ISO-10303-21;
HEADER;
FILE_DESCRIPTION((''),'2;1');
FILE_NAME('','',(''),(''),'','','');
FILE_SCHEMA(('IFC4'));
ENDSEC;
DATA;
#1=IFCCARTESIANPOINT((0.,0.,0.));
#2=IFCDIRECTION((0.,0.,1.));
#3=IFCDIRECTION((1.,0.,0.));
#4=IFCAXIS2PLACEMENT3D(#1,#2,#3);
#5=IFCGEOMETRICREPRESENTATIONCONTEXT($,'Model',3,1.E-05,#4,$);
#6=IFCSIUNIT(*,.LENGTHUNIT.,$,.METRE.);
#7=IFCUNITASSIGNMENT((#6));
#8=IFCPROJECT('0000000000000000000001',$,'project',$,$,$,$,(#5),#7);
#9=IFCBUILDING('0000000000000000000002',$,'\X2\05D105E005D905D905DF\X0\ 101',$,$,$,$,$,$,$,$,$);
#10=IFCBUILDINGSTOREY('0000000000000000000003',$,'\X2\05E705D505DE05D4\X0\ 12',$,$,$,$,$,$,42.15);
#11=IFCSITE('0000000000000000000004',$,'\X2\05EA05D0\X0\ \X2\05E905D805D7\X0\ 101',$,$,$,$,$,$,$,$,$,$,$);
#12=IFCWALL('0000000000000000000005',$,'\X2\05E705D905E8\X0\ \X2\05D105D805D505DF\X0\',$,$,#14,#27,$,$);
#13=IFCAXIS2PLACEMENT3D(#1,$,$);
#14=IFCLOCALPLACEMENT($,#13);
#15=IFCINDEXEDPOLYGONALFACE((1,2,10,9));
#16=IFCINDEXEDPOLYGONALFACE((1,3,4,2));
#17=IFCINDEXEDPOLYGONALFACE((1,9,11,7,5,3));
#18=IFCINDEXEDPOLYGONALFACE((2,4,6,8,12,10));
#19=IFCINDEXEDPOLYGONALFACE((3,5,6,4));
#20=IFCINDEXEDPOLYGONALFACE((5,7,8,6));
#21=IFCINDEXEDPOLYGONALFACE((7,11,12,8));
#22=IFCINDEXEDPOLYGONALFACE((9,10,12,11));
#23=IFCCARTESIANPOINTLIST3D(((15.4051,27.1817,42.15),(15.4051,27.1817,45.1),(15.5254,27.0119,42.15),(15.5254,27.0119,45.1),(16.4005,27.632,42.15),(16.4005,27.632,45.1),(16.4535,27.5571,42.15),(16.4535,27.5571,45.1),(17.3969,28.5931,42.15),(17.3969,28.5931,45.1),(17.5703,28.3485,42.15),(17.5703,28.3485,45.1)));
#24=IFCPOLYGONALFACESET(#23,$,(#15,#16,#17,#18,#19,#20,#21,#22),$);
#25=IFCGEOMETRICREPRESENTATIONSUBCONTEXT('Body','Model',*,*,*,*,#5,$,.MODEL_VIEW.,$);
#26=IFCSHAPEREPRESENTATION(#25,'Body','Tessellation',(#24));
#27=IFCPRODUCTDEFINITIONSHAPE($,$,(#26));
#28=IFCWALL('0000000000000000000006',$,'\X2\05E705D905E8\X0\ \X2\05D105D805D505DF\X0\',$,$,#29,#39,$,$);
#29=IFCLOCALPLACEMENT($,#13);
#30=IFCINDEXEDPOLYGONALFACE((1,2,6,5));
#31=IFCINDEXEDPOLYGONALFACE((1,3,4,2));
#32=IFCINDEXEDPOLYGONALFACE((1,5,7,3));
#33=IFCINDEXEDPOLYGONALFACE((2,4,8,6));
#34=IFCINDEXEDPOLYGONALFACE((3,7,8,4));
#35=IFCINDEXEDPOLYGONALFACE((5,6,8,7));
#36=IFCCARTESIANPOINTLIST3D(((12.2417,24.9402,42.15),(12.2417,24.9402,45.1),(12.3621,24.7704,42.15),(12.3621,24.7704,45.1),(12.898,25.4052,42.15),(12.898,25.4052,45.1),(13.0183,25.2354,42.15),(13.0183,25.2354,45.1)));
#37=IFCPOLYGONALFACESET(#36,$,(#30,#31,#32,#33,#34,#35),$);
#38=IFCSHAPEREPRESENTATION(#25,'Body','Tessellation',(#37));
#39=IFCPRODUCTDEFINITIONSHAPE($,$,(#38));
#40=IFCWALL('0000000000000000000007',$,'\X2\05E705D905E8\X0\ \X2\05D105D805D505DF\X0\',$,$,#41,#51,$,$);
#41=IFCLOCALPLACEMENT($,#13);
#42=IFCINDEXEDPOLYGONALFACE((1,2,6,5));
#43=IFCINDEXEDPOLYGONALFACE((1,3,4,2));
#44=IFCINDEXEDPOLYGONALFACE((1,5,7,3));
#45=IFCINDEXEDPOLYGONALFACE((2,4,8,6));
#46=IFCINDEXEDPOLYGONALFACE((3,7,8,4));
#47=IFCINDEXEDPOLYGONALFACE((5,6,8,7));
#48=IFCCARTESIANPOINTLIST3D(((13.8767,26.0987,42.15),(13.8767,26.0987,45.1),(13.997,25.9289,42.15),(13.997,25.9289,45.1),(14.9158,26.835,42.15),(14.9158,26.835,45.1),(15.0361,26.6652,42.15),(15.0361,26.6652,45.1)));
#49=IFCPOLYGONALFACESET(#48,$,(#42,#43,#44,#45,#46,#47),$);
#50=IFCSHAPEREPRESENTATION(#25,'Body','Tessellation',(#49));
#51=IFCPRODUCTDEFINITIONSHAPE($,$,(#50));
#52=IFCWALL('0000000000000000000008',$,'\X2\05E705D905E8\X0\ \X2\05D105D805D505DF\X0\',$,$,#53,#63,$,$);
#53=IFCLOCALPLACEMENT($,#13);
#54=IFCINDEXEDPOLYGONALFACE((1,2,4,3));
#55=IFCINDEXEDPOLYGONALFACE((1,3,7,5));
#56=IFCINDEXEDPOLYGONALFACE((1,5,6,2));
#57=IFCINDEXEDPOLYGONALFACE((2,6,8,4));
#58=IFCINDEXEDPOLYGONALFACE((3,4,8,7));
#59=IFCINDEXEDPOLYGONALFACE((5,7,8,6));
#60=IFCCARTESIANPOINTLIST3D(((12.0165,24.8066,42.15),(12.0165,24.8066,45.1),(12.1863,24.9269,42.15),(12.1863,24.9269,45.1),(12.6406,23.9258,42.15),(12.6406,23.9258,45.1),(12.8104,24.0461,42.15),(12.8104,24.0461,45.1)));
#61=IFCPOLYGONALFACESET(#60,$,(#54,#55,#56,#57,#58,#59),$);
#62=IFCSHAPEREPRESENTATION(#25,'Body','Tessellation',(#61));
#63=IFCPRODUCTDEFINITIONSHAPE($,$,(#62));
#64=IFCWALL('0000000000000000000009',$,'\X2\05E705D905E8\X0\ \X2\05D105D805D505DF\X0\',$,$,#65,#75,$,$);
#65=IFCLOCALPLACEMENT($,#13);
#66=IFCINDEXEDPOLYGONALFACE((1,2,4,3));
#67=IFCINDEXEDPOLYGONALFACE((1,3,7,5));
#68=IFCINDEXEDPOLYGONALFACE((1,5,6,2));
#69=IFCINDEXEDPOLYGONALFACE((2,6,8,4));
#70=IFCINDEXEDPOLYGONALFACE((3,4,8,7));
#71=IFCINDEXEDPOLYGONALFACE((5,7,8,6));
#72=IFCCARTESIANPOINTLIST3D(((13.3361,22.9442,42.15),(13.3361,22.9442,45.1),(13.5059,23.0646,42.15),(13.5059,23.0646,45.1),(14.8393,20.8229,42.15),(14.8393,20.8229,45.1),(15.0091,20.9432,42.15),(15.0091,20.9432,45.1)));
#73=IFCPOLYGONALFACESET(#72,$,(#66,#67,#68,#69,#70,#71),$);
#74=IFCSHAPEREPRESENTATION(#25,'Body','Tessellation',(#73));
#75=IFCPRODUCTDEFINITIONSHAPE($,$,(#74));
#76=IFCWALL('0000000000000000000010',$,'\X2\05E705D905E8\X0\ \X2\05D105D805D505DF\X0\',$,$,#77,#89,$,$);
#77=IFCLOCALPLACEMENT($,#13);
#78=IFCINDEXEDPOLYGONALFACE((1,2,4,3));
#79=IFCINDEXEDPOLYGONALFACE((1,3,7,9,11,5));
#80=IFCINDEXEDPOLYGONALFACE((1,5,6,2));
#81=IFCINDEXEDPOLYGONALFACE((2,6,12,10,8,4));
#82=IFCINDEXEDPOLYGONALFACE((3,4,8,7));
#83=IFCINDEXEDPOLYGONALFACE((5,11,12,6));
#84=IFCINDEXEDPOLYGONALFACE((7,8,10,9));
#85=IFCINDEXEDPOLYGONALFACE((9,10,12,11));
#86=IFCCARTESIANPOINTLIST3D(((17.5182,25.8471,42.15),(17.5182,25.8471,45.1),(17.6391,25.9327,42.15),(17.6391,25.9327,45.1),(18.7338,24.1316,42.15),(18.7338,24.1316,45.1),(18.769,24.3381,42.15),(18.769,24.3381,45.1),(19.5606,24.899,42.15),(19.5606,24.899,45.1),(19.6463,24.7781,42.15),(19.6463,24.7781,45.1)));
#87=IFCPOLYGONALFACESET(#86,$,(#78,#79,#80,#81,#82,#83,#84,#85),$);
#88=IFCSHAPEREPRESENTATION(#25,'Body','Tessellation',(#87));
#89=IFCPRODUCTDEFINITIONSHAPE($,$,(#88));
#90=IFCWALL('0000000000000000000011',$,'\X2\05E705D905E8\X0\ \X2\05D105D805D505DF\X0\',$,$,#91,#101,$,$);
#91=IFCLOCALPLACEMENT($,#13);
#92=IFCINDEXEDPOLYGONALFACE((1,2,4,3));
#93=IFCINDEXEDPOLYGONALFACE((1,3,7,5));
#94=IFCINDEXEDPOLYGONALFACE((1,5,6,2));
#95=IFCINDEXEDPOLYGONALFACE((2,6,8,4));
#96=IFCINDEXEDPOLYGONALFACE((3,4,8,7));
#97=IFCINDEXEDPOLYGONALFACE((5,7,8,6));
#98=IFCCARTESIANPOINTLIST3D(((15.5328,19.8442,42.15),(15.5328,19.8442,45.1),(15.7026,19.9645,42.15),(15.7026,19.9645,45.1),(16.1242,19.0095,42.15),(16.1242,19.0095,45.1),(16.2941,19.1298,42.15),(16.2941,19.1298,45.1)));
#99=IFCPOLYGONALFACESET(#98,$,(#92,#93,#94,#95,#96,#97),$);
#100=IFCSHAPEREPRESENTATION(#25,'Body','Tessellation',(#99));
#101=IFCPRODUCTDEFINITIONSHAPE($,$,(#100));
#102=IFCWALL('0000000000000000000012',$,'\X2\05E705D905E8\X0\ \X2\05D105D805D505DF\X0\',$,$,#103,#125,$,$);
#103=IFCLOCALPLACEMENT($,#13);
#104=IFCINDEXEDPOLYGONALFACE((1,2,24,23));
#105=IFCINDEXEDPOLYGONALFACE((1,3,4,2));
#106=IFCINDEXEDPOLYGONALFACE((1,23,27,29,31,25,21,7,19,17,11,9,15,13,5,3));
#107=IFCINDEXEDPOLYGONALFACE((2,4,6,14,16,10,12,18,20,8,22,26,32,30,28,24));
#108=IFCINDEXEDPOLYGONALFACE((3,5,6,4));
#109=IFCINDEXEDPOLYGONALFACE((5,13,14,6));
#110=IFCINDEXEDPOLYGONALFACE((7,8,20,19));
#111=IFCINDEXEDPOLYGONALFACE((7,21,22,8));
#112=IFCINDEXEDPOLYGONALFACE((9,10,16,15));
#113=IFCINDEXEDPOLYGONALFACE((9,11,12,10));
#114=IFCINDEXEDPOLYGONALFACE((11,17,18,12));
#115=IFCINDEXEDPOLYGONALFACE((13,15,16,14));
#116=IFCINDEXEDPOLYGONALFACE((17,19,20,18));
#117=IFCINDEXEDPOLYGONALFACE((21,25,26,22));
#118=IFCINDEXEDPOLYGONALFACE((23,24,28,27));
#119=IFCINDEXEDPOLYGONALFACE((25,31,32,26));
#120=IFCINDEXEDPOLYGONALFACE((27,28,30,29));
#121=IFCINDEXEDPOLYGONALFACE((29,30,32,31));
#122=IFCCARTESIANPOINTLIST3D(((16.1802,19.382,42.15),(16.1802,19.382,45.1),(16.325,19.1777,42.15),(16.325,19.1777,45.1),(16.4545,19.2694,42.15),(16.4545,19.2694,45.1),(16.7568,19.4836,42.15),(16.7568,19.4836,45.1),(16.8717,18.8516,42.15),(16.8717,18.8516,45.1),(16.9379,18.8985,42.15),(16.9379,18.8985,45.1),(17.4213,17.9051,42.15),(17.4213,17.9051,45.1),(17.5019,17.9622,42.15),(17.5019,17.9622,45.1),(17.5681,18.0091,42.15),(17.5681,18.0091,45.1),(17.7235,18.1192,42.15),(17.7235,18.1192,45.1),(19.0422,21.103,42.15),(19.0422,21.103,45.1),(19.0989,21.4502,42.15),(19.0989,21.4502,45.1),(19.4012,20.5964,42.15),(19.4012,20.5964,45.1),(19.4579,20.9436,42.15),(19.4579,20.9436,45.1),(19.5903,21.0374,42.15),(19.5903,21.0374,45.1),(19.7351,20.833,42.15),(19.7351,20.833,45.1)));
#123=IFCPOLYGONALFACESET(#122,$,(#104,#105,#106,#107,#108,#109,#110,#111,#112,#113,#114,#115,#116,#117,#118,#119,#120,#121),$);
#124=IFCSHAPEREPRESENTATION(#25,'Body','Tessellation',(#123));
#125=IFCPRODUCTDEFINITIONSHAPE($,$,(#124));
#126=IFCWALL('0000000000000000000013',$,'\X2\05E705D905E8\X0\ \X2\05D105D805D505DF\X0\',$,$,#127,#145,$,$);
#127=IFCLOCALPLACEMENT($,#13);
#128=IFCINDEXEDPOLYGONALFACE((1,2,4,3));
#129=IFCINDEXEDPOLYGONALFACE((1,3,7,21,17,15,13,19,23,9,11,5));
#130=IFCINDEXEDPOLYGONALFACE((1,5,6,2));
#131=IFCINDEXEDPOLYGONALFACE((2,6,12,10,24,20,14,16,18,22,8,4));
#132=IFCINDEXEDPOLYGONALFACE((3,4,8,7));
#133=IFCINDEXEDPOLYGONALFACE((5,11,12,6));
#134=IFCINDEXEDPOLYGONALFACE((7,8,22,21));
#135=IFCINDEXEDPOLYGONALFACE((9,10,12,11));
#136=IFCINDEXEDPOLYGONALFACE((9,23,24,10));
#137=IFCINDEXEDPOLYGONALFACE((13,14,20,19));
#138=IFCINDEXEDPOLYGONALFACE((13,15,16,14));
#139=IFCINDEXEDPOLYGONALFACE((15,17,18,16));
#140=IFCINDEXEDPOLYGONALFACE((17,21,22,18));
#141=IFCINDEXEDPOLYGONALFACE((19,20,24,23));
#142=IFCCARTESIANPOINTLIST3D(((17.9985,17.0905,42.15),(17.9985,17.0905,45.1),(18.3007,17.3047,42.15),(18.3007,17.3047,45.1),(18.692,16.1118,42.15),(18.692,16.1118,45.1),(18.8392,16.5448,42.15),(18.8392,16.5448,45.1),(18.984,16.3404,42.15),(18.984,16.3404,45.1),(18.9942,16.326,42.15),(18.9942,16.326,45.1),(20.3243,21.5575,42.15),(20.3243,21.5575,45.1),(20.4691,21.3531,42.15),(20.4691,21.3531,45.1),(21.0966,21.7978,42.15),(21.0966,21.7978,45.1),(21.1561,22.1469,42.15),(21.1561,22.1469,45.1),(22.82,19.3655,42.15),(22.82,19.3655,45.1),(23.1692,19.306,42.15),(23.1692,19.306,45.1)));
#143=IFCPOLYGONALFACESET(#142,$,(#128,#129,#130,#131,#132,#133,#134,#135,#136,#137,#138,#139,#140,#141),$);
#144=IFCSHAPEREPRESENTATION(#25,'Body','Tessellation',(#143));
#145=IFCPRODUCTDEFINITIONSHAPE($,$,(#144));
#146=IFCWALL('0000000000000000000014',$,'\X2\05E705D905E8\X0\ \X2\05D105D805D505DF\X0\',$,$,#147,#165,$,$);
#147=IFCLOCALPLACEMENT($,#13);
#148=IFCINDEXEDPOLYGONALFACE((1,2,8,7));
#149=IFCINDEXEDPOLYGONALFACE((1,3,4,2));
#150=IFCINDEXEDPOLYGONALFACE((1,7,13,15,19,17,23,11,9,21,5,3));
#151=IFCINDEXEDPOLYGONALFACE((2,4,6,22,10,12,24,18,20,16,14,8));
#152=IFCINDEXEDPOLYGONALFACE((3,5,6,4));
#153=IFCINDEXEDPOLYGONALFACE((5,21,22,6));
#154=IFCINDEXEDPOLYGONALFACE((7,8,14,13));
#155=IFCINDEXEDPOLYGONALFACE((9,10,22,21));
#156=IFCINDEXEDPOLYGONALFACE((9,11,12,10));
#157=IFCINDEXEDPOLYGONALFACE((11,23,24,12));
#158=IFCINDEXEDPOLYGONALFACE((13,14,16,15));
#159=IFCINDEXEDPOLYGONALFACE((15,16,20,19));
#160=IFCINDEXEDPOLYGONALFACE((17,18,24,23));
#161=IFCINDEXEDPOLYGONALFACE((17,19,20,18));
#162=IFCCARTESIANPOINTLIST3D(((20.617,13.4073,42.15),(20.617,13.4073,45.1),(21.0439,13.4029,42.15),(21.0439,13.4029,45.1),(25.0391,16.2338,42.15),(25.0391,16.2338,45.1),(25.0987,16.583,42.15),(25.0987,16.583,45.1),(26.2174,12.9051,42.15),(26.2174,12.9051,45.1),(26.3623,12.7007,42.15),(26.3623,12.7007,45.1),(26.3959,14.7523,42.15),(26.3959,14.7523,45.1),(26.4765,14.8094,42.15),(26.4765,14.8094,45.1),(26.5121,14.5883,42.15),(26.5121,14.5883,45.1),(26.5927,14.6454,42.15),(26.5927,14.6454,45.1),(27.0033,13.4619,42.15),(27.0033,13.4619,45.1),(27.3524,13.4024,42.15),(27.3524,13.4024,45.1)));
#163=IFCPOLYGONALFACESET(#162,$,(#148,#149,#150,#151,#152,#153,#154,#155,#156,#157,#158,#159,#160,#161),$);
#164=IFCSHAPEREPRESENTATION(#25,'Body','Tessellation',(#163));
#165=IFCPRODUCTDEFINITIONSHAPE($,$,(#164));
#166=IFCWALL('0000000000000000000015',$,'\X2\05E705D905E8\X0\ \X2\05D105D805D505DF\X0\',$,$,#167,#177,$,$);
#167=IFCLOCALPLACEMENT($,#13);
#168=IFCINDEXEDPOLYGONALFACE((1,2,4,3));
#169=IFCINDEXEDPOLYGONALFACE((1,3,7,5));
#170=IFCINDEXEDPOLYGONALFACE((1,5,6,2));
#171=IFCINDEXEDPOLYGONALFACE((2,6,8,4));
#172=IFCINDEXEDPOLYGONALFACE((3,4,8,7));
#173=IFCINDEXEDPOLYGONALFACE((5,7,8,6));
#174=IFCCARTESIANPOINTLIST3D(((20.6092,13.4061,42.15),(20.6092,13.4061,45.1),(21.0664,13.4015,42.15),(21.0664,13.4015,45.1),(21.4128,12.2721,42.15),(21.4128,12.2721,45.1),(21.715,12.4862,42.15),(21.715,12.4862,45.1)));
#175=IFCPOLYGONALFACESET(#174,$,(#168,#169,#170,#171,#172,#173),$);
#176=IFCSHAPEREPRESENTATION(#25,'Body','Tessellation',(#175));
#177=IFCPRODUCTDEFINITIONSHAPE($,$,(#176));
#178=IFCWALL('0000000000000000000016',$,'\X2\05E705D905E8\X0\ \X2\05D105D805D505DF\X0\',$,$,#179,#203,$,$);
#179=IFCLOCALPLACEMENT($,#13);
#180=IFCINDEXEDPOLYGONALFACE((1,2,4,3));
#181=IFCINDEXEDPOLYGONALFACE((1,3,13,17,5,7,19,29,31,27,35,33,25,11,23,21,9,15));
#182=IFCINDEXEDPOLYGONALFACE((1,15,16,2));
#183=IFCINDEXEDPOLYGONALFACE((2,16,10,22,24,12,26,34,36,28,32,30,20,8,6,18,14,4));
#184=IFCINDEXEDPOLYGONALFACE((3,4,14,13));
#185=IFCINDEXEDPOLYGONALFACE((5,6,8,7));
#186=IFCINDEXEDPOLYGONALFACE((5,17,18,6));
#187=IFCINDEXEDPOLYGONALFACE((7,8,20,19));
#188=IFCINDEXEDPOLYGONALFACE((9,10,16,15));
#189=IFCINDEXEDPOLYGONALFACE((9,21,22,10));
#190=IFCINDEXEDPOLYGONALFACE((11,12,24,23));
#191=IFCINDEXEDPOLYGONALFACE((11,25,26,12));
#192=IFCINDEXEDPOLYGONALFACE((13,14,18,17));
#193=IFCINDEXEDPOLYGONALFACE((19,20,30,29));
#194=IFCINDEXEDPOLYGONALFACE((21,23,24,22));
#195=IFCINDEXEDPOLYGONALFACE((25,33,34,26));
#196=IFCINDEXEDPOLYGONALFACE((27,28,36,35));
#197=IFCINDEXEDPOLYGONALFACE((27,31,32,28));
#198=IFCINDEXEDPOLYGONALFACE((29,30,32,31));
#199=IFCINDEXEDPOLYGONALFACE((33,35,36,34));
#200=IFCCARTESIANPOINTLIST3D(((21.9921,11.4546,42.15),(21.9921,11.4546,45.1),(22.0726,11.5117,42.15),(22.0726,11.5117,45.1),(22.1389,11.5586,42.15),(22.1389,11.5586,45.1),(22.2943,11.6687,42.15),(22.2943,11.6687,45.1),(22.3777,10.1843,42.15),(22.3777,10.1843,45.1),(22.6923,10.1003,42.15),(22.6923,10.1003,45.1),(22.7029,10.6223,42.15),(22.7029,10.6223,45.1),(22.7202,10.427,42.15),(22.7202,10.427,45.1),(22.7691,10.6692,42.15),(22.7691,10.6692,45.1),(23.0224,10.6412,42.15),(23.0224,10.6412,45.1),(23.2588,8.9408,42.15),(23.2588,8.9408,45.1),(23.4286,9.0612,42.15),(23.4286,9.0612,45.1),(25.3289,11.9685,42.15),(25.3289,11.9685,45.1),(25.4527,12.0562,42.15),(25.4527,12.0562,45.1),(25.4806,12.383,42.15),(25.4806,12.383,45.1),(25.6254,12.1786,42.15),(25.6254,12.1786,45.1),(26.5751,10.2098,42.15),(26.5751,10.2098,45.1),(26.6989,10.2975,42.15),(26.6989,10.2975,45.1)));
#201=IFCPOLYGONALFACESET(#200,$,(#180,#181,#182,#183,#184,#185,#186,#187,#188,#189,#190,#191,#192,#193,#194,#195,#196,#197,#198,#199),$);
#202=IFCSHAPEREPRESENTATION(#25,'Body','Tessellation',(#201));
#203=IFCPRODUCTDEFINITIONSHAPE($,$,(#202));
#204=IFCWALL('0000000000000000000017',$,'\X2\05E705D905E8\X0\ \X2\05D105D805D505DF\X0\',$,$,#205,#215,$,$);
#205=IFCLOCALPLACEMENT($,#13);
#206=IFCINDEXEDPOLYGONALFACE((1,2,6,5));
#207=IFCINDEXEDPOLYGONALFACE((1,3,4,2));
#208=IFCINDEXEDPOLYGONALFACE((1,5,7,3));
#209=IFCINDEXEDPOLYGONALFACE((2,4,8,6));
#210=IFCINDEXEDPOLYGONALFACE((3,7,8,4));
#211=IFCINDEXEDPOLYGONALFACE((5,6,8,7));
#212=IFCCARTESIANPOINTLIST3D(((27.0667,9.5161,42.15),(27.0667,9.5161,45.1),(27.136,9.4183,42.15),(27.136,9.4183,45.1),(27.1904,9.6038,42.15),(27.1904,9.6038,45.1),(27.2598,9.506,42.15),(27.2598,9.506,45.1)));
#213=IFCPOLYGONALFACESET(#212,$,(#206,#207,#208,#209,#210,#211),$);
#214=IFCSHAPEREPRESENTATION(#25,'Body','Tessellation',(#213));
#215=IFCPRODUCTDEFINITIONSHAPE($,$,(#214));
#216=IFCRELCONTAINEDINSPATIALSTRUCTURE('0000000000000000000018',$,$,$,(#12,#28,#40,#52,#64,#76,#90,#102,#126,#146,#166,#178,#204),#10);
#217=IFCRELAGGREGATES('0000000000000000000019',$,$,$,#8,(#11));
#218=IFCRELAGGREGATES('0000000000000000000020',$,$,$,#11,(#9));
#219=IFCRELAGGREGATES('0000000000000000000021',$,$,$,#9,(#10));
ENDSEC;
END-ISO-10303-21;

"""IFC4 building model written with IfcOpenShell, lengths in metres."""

from ifc_helpers import new_model, si_unit, frame, origin_with_axes, context, subcontext, project, spatial, polyline, outline, extrude, element, save


model = new_model("IFC4")

# Units and contexts
model_context = context("Model", 3, precision=1e-05, world=origin_with_axes())
body_context = subcontext(model_context, "Body", "Model", "MODEL_VIEW")
ifc_project = project(units=[si_unit("LENGTHUNIT", "METRE")], contexts=[model_context])

# Site, building, storey
site = spatial("IfcSite", under=ifc_project, Name="תא שטח 101")
building = spatial("IfcBuilding", under=site, Name="בניין 101")
storey = spatial("IfcBuildingStorey", under=building, Name="קומה 12", Elevation=42.15)

# Walls
element("IfcWall", 1, inside=storey, Name="קיר בטון", context=body_context, shape_type="SweptSolid", body=[
    extrude(outline(polyline([(16.4535, 27.5571), (17.5703, 28.3485), (17.3969, 28.5931), (15.4051, 27.1817), (15.5254, 27.0119), (16.4005, 27.632), (16.4535, 27.5571)])), frame((0.0, 0.0, 42.15)), (0.0, 0.0, 1.0), 2.95),
])
element("IfcWall", 2, inside=storey, Name="קיר בטון", context=body_context, shape_type="SweptSolid", body=[
    extrude(outline(polyline([(12.898, 25.4052), (12.2417, 24.9402), (12.3621, 24.7704), (13.0183, 25.2354), (12.898, 25.4052)])), frame((0.0, 0.0, 42.15)), (0.0, 0.0, 1.0), 2.95),
])
element("IfcWall", 3, inside=storey, Name="קיר בטון", context=body_context, shape_type="SweptSolid", body=[
    extrude(outline(polyline([(14.9158, 26.835), (13.8767, 26.0987), (13.997, 25.9289), (15.0361, 26.6652), (14.9158, 26.835)])), frame((0.0, 0.0, 42.15)), (0.0, 0.0, 1.0), 2.95),
])
element("IfcWall", 4, inside=storey, Name="קיר בטון", context=body_context, shape_type="SweptSolid", body=[
    extrude(outline(polyline([(12.8104, 24.0461), (12.1863, 24.9269), (12.0165, 24.8066), (12.6406, 23.9258), (12.8104, 24.0461)])), frame((0.0, 0.0, 42.15)), (0.0, 0.0, 1.0), 2.95),
])
element("IfcWall", 5, inside=storey, Name="קיר בטון", context=body_context, shape_type="SweptSolid", body=[
    extrude(outline(polyline([(14.8393, 20.8229), (15.0091, 20.9432), (13.5059, 23.0646), (13.3361, 22.9442), (14.8393, 20.8229)])), frame((0.0, 0.0, 42.15)), (0.0, 0.0, 1.0), 2.95),
])
element("IfcWall", 6, inside=storey, Name="קיר בטון", context=body_context, shape_type="SweptSolid", body=[
    extrude(outline(polyline([(18.7338, 24.1316), (19.6463, 24.7781), (19.5606, 24.899), (18.769, 24.3381), (17.6391, 25.9327), (17.5182, 25.8471), (18.7338, 24.1316)])), frame((0.0, 0.0, 42.15)), (0.0, 0.0, 1.0), 2.95),
])
element("IfcWall", 7, inside=storey, Name="קיר בטון", context=body_context, shape_type="SweptSolid", body=[
    extrude(outline(polyline([(15.7026, 19.9645), (15.5328, 19.8442), (16.1242, 19.0095), (16.2941, 19.1298), (15.7026, 19.9645)])), frame((0.0, 0.0, 42.15)), (0.0, 0.0, 1.0), 2.95),
])
element("IfcWall", 8, inside=storey, Name="קיר בטון", context=body_context, shape_type="SweptSolid", body=[
    extrude(outline(polyline([(19.4579, 20.9436), (19.0989, 21.4502), (16.1802, 19.382), (16.325, 19.1777), (16.4545, 19.2694), (17.4213, 17.9051), (17.5019, 17.9622), (16.8717, 18.8516), (16.9379, 18.8985), (17.5681, 18.0091), (17.7235, 18.1192), (16.7568, 19.4836), (19.0422, 21.103), (19.4012, 20.5964), (19.7351, 20.833), (19.5903, 21.0374), (19.4579, 20.9436)])), frame((0.0, 0.0, 42.15)), (0.0, 0.0, 1.0), 2.95),
])
element("IfcWall", 9, inside=storey, Name="קיר בטון", context=body_context, shape_type="SweptSolid", body=[
    extrude(outline(polyline([(18.692, 16.1118), (18.9942, 16.326), (18.984, 16.3404), (23.1692, 19.306), (21.1561, 22.1469), (20.3243, 21.5575), (20.4691, 21.3531), (21.0966, 21.7978), (22.82, 19.3655), (18.8392, 16.5448), (18.3007, 17.3047), (17.9985, 17.0905), (18.692, 16.1118)])), frame((0.0, 0.0, 42.15)), (0.0, 0.0, 1.0), 2.95),
])
element("IfcWall", 10, inside=storey, Name="קיר בטון", context=body_context, shape_type="SweptSolid", body=[
    extrude(outline(polyline([(20.617, 13.4073), (21.0439, 13.4029), (25.0391, 16.2338), (27.0033, 13.4619), (26.2174, 12.9051), (26.3623, 12.7007), (27.3524, 13.4024), (26.5121, 14.5883), (26.5927, 14.6454), (26.4765, 14.8094), (26.3959, 14.7523), (25.0987, 16.583), (20.617, 13.4073)])), frame((0.0, 0.0, 42.15)), (0.0, 0.0, 1.0), 2.95),
])
element("IfcWall", 11, inside=storey, Name="קיר בטון", context=body_context, shape_type="SweptSolid", body=[
    extrude(outline(polyline([(21.715, 12.4862), (21.0664, 13.4015), (20.6092, 13.4061), (21.4128, 12.2721), (21.715, 12.4862)])), frame((0.0, 0.0, 42.15)), (0.0, 0.0, 1.0), 2.95),
])
element("IfcWall", 12, inside=storey, Name="קיר בטון", context=body_context, shape_type="SweptSolid", body=[
    extrude(outline(polyline([(21.9921, 11.4546), (22.7202, 10.427), (22.3777, 10.1843), (23.2588, 8.9408), (23.4286, 9.0612), (22.6923, 10.1003), (25.3289, 11.9685), (26.5751, 10.2098), (26.6989, 10.2975), (25.4527, 12.0562), (25.6254, 12.1786), (25.4806, 12.383), (23.0224, 10.6412), (22.2943, 11.6687), (22.1389, 11.5586), (22.7691, 10.6692), (22.7029, 10.6223), (22.0726, 11.5117), (21.9921, 11.4546)])), frame((0.0, 0.0, 42.15)), (0.0, 0.0, 1.0), 2.95),
])
element("IfcWall", 13, inside=storey, Name="קיר בטון", context=body_context, shape_type="SweptSolid", body=[
    extrude(outline(polyline([(27.0667, 9.5161), (27.136, 9.4183), (27.2598, 9.506), (27.1904, 9.6038), (27.0667, 9.5161)])), frame((0.0, 0.0, 42.15)), (0.0, 0.0, 1.0), 2.95),
])

save(model, "model.ifc")
